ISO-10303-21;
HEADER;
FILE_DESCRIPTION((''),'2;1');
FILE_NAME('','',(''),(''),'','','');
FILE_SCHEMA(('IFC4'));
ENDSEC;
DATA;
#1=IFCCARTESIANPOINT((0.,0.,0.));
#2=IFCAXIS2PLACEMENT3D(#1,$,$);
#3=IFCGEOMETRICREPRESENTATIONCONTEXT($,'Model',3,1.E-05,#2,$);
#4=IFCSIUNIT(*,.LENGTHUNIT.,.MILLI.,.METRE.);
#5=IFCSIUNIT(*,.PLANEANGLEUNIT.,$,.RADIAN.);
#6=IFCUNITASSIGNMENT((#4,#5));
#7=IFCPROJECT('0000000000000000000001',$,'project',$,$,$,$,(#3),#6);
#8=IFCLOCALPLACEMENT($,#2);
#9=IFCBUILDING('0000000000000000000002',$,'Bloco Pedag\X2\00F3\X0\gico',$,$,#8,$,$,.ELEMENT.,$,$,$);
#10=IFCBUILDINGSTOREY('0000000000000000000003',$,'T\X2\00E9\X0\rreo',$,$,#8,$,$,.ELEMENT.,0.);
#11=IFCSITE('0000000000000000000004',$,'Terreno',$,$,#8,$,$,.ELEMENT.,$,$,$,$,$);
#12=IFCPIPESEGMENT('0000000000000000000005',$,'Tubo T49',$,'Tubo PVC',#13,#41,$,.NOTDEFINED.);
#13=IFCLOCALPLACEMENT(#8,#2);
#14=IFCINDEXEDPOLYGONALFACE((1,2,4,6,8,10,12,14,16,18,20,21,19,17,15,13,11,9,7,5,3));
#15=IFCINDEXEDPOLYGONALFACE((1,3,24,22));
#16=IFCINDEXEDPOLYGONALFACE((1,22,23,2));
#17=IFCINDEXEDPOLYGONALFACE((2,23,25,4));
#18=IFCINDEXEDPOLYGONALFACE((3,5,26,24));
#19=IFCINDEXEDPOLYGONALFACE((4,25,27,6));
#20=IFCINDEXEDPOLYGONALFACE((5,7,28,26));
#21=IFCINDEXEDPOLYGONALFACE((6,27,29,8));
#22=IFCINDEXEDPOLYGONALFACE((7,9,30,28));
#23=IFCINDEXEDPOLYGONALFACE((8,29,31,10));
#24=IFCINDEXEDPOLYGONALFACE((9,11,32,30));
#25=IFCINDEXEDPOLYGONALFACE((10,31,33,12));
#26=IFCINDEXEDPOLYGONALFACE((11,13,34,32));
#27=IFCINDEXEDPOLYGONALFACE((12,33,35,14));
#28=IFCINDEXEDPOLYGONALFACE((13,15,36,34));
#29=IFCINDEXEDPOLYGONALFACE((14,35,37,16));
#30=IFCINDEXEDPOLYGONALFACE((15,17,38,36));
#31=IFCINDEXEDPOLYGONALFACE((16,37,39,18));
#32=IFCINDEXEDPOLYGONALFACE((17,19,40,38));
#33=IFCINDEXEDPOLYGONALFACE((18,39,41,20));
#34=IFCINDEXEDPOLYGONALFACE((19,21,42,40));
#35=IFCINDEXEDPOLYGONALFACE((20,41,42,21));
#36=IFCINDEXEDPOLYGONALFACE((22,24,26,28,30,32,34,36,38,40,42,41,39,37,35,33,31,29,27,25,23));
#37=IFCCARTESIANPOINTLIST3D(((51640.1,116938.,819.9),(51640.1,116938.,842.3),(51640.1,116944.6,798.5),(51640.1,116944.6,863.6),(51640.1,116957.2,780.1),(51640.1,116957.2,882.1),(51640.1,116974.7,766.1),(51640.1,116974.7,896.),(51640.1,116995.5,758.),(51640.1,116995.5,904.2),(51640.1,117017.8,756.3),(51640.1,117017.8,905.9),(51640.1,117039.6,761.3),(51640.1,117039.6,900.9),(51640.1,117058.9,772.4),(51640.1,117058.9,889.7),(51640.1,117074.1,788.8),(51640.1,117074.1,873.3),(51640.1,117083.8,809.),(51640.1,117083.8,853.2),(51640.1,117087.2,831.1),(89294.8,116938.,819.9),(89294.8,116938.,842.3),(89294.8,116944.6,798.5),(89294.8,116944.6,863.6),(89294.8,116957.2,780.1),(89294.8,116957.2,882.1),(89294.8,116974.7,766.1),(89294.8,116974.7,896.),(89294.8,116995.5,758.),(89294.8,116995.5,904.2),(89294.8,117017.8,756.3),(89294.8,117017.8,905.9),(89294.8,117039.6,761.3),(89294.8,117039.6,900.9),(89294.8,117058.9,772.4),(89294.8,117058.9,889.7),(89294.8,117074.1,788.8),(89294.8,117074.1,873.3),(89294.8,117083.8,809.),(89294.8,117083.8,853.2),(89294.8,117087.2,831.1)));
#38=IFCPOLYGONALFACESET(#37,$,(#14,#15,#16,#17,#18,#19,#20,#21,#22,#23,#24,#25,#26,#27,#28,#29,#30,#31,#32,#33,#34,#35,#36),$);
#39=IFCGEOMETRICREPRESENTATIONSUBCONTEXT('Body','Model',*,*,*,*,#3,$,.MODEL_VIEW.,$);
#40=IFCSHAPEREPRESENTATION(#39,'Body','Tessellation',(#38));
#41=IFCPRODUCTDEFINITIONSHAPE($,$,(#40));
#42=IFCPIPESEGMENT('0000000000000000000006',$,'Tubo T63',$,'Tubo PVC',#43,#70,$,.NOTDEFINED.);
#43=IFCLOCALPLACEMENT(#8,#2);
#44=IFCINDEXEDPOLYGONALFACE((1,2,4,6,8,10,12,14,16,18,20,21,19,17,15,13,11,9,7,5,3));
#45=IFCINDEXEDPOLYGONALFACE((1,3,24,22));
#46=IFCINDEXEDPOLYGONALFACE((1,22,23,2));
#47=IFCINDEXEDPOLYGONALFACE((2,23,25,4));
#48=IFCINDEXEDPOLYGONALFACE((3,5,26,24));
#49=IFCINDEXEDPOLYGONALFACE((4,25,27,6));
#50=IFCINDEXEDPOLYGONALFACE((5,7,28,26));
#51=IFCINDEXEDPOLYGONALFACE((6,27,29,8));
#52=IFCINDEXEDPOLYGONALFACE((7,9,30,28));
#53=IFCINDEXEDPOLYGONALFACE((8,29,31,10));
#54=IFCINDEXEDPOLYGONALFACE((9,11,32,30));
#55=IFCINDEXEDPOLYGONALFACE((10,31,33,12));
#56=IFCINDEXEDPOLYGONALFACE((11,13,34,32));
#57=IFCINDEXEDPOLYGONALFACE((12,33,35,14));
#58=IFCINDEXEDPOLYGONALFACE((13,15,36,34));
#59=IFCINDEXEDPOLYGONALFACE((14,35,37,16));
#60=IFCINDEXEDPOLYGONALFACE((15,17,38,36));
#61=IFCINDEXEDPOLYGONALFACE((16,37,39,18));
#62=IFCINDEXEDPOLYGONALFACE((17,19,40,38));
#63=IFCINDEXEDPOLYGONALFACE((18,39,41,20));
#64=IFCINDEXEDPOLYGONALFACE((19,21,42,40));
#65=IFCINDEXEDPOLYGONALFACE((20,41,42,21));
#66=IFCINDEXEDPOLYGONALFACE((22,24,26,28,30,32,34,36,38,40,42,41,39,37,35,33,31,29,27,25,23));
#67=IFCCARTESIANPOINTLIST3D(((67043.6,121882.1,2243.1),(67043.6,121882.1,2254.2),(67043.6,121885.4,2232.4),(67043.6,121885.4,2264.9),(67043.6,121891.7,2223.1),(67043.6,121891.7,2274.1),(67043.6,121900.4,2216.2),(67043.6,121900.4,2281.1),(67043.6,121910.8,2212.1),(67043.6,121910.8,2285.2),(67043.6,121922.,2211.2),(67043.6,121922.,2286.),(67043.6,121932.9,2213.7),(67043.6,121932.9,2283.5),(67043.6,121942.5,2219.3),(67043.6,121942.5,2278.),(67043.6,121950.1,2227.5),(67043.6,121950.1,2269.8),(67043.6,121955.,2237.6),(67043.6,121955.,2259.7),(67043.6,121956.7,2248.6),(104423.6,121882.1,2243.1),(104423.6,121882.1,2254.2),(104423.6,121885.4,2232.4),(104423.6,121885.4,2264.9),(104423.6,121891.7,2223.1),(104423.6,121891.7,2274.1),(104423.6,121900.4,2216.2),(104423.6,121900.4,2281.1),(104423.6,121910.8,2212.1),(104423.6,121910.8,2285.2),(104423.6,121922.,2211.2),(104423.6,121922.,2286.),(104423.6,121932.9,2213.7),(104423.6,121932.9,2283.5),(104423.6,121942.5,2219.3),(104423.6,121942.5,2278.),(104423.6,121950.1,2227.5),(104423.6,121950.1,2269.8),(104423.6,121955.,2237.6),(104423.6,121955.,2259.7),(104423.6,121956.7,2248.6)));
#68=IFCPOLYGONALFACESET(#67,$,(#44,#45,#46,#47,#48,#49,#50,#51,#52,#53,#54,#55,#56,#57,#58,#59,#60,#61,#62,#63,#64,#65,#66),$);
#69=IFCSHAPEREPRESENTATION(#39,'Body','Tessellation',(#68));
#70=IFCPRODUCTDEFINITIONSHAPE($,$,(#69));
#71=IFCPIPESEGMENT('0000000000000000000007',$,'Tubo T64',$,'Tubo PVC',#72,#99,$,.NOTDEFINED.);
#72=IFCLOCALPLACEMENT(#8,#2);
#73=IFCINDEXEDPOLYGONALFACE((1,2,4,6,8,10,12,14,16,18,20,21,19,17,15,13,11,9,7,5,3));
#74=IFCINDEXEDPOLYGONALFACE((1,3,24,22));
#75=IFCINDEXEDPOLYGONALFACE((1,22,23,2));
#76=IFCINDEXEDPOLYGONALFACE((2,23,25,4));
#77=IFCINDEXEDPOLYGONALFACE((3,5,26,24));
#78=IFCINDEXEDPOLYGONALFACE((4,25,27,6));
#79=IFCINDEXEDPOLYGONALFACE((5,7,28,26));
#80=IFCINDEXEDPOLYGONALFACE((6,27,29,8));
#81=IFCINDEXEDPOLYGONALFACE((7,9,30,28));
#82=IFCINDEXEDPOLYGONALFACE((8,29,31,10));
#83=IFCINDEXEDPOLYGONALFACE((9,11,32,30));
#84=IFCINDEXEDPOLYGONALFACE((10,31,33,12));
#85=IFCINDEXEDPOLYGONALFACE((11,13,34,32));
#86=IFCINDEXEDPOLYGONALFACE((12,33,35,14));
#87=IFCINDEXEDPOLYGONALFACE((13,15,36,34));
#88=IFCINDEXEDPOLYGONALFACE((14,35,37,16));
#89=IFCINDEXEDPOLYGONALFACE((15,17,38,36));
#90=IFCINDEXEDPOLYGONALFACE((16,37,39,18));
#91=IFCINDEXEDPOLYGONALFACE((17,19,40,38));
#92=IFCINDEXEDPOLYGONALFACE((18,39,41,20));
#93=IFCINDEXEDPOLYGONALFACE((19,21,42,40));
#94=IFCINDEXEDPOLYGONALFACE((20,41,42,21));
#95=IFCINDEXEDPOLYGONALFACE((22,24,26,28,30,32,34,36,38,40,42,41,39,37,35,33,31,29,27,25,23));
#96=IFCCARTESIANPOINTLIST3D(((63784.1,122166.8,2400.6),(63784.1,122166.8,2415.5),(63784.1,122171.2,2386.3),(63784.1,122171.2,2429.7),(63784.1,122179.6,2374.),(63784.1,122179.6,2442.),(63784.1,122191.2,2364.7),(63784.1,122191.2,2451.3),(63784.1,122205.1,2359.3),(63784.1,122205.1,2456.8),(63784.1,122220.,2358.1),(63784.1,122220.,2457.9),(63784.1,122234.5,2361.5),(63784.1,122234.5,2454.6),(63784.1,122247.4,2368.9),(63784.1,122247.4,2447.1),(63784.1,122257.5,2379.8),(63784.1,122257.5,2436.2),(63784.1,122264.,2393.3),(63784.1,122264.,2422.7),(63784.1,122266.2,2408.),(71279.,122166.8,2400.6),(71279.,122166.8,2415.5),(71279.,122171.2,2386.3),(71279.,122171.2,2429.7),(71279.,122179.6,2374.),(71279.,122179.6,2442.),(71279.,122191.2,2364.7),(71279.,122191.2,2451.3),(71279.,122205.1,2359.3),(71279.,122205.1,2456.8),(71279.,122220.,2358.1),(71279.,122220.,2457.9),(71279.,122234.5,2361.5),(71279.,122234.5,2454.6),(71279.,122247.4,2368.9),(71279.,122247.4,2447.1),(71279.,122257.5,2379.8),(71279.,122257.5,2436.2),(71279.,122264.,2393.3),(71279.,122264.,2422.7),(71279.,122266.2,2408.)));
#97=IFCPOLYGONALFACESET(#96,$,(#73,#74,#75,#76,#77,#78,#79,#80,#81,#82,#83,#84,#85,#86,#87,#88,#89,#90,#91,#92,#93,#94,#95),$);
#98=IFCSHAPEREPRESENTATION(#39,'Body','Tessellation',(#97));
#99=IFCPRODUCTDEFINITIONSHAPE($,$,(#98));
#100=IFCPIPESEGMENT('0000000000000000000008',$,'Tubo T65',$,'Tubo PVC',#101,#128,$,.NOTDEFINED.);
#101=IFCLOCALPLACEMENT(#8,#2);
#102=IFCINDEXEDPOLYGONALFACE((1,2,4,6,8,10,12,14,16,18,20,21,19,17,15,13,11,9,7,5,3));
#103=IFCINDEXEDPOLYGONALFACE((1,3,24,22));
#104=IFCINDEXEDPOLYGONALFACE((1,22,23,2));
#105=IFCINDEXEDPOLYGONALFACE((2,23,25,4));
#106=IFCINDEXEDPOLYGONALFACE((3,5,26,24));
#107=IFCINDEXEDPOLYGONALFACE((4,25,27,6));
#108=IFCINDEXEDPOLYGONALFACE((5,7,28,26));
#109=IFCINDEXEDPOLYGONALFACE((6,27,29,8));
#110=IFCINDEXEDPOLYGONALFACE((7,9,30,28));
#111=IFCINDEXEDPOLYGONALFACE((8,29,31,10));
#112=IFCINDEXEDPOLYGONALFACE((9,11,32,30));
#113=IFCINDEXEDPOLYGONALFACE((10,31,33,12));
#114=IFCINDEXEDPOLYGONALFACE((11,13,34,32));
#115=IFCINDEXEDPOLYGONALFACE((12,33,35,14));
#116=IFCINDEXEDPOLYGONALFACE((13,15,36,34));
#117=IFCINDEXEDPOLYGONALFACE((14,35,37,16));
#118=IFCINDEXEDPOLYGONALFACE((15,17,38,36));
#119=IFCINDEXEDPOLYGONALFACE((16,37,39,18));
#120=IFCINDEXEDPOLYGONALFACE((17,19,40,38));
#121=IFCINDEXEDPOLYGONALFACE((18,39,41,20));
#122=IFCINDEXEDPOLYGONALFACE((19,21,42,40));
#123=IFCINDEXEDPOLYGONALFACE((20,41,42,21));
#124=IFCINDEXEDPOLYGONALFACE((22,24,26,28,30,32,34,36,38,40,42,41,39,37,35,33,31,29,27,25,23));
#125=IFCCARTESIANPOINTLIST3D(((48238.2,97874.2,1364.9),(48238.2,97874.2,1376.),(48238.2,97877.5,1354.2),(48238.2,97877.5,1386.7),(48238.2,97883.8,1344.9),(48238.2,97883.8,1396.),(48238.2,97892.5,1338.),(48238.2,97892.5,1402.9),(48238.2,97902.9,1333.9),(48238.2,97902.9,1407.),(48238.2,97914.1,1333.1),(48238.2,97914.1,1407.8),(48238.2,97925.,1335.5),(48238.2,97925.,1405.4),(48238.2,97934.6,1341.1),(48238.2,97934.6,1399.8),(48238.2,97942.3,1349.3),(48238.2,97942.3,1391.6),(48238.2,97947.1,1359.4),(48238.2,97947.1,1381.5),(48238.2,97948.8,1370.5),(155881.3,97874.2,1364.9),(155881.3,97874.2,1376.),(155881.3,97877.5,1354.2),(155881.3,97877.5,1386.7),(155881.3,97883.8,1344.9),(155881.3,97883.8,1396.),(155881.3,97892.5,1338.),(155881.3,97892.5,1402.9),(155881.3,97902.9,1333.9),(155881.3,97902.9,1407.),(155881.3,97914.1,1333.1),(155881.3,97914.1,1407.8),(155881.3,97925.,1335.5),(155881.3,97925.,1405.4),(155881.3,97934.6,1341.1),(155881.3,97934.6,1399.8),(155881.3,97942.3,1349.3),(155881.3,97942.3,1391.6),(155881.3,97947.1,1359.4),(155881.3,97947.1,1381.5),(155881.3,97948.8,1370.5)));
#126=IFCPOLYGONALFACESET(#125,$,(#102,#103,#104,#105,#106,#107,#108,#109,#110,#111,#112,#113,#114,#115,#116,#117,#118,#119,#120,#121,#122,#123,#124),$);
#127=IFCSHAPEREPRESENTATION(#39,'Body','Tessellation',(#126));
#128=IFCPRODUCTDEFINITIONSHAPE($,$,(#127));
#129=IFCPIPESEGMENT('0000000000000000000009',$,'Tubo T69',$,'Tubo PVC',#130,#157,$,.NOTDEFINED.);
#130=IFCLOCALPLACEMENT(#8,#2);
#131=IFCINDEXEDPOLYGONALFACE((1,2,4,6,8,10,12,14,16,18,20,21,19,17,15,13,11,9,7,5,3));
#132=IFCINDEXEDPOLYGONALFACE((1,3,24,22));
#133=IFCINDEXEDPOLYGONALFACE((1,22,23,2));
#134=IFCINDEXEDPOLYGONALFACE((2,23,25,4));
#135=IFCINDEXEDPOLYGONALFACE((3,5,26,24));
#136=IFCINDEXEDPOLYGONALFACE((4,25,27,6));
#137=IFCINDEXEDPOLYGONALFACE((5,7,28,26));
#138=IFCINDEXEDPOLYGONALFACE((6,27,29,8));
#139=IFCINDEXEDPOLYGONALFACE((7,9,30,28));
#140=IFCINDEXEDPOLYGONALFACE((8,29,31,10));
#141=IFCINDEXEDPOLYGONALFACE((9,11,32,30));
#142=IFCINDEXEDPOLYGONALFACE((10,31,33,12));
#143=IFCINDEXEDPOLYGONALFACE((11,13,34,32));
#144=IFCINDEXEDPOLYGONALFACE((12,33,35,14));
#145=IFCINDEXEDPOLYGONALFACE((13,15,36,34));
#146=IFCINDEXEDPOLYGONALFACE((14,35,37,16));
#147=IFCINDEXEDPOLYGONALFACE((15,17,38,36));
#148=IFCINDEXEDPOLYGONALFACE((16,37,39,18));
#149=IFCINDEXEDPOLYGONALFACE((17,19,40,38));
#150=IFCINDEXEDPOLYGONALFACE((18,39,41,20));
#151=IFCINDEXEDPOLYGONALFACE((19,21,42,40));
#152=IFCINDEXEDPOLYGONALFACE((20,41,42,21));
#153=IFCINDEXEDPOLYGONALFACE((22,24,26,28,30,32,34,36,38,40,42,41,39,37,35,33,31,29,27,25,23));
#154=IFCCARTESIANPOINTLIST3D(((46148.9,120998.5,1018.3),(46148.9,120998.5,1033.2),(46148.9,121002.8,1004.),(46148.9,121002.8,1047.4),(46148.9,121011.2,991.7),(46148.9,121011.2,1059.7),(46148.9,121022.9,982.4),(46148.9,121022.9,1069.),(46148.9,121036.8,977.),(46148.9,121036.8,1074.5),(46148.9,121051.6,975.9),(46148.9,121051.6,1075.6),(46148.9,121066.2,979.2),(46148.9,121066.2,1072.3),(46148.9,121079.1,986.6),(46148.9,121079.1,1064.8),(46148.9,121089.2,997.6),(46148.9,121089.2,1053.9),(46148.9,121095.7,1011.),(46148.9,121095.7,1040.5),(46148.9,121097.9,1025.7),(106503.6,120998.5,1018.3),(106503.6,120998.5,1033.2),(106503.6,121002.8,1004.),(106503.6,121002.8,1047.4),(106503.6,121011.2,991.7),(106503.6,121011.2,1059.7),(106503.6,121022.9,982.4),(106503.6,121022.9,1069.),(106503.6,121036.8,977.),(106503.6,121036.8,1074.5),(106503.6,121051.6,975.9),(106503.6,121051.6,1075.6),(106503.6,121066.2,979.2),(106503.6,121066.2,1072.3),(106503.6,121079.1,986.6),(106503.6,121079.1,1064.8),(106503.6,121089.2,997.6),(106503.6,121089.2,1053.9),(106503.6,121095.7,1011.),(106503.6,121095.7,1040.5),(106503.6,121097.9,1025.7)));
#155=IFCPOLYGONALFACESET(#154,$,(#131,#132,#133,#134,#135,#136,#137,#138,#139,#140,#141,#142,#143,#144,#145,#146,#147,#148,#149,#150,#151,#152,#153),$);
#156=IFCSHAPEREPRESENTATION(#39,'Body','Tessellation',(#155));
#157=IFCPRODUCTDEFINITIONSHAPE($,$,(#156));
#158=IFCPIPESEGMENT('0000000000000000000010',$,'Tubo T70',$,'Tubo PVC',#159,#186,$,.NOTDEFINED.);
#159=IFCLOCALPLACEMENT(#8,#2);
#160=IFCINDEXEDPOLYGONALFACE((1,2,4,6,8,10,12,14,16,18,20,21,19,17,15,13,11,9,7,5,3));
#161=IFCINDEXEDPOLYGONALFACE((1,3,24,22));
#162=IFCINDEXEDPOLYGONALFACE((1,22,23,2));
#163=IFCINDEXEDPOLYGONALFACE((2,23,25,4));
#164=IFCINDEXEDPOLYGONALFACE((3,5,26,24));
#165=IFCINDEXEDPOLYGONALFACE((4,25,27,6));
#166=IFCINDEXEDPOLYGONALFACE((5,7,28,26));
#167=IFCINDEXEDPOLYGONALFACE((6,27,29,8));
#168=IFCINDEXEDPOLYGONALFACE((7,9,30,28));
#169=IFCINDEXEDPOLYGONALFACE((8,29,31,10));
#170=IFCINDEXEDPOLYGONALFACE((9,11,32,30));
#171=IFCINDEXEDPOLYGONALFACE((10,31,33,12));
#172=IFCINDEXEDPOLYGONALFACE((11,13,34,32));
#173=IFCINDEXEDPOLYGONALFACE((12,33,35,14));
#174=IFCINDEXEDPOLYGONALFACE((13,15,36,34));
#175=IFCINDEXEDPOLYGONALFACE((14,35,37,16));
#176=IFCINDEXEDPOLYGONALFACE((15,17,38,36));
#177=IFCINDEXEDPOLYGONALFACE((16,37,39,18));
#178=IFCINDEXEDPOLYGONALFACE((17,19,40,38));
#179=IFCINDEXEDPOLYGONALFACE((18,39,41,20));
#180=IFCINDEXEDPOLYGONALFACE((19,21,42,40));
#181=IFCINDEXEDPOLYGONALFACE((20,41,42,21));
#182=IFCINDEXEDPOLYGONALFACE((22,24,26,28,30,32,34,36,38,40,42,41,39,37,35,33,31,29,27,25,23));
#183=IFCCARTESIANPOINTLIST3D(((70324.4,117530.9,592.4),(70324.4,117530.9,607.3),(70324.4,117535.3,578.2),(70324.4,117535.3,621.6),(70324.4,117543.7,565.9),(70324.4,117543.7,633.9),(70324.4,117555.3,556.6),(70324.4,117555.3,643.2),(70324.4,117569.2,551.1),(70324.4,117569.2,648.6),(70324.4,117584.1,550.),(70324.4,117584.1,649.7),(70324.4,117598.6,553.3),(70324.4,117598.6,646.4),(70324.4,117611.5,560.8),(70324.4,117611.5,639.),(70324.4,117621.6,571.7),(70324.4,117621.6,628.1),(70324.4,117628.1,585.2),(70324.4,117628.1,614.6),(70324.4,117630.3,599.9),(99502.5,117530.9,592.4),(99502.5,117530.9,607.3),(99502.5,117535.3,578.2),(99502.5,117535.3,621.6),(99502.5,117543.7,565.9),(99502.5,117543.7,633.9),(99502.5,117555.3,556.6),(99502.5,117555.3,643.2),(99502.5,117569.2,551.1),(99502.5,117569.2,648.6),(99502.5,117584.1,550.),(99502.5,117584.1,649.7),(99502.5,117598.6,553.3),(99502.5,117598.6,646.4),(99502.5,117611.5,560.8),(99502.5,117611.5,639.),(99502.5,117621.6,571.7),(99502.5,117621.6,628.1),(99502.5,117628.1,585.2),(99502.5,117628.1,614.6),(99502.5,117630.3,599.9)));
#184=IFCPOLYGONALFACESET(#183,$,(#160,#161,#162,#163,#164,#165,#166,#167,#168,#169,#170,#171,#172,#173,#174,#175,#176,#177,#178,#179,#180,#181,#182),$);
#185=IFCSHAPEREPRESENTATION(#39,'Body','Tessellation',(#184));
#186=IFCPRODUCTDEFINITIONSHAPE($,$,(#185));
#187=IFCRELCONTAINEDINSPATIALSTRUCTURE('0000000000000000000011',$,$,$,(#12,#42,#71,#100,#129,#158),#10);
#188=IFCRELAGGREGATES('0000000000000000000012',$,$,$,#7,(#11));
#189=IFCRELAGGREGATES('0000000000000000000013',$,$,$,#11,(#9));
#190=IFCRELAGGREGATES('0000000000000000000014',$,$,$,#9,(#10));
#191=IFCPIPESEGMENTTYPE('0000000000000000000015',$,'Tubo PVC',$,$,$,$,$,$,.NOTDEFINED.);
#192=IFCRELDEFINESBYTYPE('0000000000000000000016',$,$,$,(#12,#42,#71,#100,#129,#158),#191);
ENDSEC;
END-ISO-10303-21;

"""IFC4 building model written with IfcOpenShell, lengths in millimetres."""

from ifc_helpers import new_model, si_unit, frame, origin, origin_2d, place, context, subcontext, project, spatial, circle, extrude, type_object, element, save


model = new_model("IFC4")

# Units and contexts
model_context = context("Model", 3, precision=1e-05, world=origin())
body_context = subcontext(model_context, "Body", "Model", "MODEL_VIEW")
ifc_project = project(units=[si_unit("LENGTHUNIT", "METRE", prefix="MILLI"), si_unit("PLANEANGLEUNIT", "RADIAN")], contexts=[model_context])

# Site, building, storey
placement = place(None, origin())
site = spatial("IfcSite", under=ifc_project, at=placement, Name="Terreno", CompositionType="ELEMENT")
building = spatial("IfcBuilding", under=site, at=placement, Name="Bloco Pedagógico", CompositionType="ELEMENT")
storey = spatial("IfcBuildingStorey", under=building, at=placement, Name="Térreo", CompositionType="ELEMENT", Elevation=0.0)

# Pipe segments
pipe_segment_type = type_object("IfcPipeSegmentType", Name="Tubo PVC", PredefinedType="NOTDEFINED")
pipe_segment_1_placement = place(None, frame((51640.1, 117012.2, 831.1), z_axis=(1.0, 0.0, 0.0), x_axis=(0.0, 1.0, 0.0)))
element("IfcPipeSegment", 1, at=pipe_segment_1_placement, inside=storey, type_object=pipe_segment_type, Name="Tubo T49", ObjectType="Tubo PVC", PredefinedType="NOTDEFINED", context=body_context, shape_type="SweptSolid", body=[
    extrude(circle(Radius=75.0, at=origin_2d()), None, (0.0, 0.0, 1.0), 37654.7),
])
pipe_segment_2_placement = place(None, frame((67043.6, 121919.2, 2248.6), z_axis=(1.0, 0.0, 0.0), x_axis=(0.0, 1.0, 0.0)))
element("IfcPipeSegment", 2, at=pipe_segment_2_placement, inside=storey, type_object=pipe_segment_type, Name="Tubo T63", ObjectType="Tubo PVC", PredefinedType="NOTDEFINED", context=body_context, shape_type="SweptSolid", body=[
    extrude(circle(Radius=37.5, at=origin_2d()), None, (0.0, 0.0, 1.0), 37380.0),
])
pipe_segment_3_placement = place(None, frame((63784.1, 122216.2, 2408.0), z_axis=(1.0, 0.0, 0.0), x_axis=(0.0, 1.0, 0.0)))
element("IfcPipeSegment", 3, at=pipe_segment_3_placement, inside=storey, type_object=pipe_segment_type, Name="Tubo T64", ObjectType="Tubo PVC", PredefinedType="NOTDEFINED", context=body_context, shape_type="SweptSolid", body=[
    extrude(circle(Radius=50.0, at=origin_2d()), None, (0.0, 0.0, 1.0), 7494.9),
])
pipe_segment_4_placement = place(None, frame((48238.2, 97911.3, 1370.5), z_axis=(1.0, 0.0, 0.0), x_axis=(0.0, 1.0, 0.0)))
element("IfcPipeSegment", 4, at=pipe_segment_4_placement, inside=storey, type_object=pipe_segment_type, Name="Tubo T65", ObjectType="Tubo PVC", PredefinedType="NOTDEFINED", context=body_context, shape_type="SweptSolid", body=[
    extrude(circle(Radius=37.5, at=origin_2d()), None, (0.0, 0.0, 1.0), 107643.1),
])
pipe_segment_5_placement = place(None, frame((46148.9, 121047.9, 1025.7), z_axis=(1.0, 0.0, 0.0), x_axis=(0.0, 1.0, 0.0)))
element("IfcPipeSegment", 5, at=pipe_segment_5_placement, inside=storey, type_object=pipe_segment_type, Name="Tubo T69", ObjectType="Tubo PVC", PredefinedType="NOTDEFINED", context=body_context, shape_type="SweptSolid", body=[
    extrude(circle(Radius=50.0, at=origin_2d()), None, (0.0, 0.0, 1.0), 60354.7),
])
pipe_segment_6_placement = place(None, frame((70324.4, 117580.3, 599.9), z_axis=(1.0, 0.0, 0.0), x_axis=(0.0, 1.0, 0.0)))
element("IfcPipeSegment", 6, at=pipe_segment_6_placement, inside=storey, type_object=pipe_segment_type, Name="Tubo T70", ObjectType="Tubo PVC", PredefinedType="NOTDEFINED", context=body_context, shape_type="SweptSolid", body=[
    extrude(circle(Radius=50.0, at=origin_2d()), None, (0.0, 0.0, 1.0), 29178.1),
])

save(model, "model.ifc")
